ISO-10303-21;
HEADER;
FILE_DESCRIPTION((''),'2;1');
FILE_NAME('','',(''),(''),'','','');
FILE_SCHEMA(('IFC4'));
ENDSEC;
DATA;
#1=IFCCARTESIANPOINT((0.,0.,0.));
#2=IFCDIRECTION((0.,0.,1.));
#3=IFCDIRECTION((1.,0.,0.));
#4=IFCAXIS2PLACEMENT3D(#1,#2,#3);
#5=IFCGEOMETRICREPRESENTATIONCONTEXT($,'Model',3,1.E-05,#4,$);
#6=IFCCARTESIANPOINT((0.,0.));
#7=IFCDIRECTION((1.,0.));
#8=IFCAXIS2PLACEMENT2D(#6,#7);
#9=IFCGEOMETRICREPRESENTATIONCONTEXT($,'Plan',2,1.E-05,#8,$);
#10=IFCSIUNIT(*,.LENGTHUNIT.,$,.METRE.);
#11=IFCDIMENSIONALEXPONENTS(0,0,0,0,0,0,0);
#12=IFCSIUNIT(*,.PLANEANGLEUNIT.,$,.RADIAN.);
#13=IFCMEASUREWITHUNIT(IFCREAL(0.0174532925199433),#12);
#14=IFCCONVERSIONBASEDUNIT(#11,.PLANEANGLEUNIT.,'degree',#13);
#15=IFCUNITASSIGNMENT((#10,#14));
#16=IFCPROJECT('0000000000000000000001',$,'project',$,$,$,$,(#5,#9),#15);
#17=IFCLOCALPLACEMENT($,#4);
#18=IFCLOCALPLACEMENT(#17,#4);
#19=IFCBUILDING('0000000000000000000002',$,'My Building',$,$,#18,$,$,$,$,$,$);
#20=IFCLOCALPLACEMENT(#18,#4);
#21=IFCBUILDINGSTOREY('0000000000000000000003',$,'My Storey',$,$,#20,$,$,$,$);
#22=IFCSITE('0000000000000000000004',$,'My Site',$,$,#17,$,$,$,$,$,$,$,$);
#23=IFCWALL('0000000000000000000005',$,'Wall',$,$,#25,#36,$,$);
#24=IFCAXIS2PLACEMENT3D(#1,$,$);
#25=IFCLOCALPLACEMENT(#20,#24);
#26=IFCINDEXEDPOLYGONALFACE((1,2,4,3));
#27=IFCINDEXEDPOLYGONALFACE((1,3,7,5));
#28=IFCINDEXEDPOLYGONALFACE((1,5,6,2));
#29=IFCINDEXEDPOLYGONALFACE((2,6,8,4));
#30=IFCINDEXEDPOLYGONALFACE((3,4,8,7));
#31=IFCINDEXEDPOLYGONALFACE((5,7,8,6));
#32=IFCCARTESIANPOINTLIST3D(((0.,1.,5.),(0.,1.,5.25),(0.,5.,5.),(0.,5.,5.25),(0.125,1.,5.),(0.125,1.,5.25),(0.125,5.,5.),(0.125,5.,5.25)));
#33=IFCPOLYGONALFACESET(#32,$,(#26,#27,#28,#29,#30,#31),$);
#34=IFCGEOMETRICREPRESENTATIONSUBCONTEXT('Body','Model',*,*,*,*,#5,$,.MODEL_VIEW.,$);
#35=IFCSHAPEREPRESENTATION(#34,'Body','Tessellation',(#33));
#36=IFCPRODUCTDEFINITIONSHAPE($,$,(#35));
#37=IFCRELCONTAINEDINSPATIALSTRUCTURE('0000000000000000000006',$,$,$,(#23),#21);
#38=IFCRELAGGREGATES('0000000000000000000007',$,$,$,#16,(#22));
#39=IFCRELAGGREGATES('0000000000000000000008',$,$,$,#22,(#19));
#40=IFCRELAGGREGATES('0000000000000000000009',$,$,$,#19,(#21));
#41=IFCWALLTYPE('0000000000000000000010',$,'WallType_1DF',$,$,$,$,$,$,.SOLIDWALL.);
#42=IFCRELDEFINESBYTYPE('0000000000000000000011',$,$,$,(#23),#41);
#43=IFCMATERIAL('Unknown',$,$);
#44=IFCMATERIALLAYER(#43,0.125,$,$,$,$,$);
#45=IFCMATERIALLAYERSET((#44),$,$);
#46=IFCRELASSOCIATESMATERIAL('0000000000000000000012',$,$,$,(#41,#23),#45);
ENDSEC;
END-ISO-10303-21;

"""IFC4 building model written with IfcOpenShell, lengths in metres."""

from ifc_helpers import new_model, entity, si_unit, converted_unit, frame, origin_with_axes, origin_2d_with_axis, place, context, subcontext, project, spatial, indexed_curve, outline, extrude, material, layer, layer_set, layer_usage, type_object, element, save


model = new_model("IFC4")

# Units and contexts
model_context = context("Model", 3, precision=1e-05, world=origin_with_axes())
plan_context = context("Plan", 2, precision=1e-05, world=origin_2d_with_axis())
body_context_1 = subcontext(model_context, "Body", "Model", "MODEL_VIEW")
ifc_project = project(units=[si_unit("LENGTHUNIT", "METRE"), converted_unit("PLANEANGLEUNIT", "degree", entity("IfcReal", 0.0174532925199433), si_unit("PLANEANGLEUNIT", "RADIAN"), dimensions=[0, 0, 0, 0, 0, 0, 0])], contexts=[model_context, plan_context])

# Site, building, storey
site_placement = place(None, origin_with_axes())
site = spatial("IfcSite", under=ifc_project, at=site_placement, Name="My Site")
building_placement = place(site_placement, origin_with_axes())
building = spatial("IfcBuilding", under=site, at=building_placement, Name="My Building")
storey_placement = place(building_placement, origin_with_axes())
storey = spatial("IfcBuildingStorey", under=building, at=storey_placement, Name="My Storey")

# Wall
ifc_material = material(Name="Unknown")
ifc_layer_1 = layer(ifc_material, 0.125)
ifc_layer_set_1 = layer_set([ifc_layer_1])
ifc_layer_usage_1 = layer_usage(ifc_layer_set_1, "AXIS2", "POSITIVE", 0.0)
wall_type_1 = type_object("IfcWallType", Name="WallType_1DF", PredefinedType="SOLIDWALL", material=ifc_layer_set_1)
wall_1_placement = place(storey_placement, frame((0.125, 1.0, 5.0), z_axis=(0.0, 0.0, 1.0), x_axis=(0.0, 1.0, 0.0)))
element("IfcWall", 1, at=wall_1_placement, inside=storey, type_object=wall_type_1, material=ifc_layer_usage_1, Name="Wall", context=body_context_1, shape_type="SweptSolid", body=[
    extrude(outline(indexed_curve([(0.0, 0.0), (0.0, 0.125), (4.0, 0.125), (4.0, 0.0), (0.0, 0.0)], self_intersect=False)), origin_with_axes(), (0.0, 0.0, 1.0), 0.25),
])

save(model, "model.ifc")
